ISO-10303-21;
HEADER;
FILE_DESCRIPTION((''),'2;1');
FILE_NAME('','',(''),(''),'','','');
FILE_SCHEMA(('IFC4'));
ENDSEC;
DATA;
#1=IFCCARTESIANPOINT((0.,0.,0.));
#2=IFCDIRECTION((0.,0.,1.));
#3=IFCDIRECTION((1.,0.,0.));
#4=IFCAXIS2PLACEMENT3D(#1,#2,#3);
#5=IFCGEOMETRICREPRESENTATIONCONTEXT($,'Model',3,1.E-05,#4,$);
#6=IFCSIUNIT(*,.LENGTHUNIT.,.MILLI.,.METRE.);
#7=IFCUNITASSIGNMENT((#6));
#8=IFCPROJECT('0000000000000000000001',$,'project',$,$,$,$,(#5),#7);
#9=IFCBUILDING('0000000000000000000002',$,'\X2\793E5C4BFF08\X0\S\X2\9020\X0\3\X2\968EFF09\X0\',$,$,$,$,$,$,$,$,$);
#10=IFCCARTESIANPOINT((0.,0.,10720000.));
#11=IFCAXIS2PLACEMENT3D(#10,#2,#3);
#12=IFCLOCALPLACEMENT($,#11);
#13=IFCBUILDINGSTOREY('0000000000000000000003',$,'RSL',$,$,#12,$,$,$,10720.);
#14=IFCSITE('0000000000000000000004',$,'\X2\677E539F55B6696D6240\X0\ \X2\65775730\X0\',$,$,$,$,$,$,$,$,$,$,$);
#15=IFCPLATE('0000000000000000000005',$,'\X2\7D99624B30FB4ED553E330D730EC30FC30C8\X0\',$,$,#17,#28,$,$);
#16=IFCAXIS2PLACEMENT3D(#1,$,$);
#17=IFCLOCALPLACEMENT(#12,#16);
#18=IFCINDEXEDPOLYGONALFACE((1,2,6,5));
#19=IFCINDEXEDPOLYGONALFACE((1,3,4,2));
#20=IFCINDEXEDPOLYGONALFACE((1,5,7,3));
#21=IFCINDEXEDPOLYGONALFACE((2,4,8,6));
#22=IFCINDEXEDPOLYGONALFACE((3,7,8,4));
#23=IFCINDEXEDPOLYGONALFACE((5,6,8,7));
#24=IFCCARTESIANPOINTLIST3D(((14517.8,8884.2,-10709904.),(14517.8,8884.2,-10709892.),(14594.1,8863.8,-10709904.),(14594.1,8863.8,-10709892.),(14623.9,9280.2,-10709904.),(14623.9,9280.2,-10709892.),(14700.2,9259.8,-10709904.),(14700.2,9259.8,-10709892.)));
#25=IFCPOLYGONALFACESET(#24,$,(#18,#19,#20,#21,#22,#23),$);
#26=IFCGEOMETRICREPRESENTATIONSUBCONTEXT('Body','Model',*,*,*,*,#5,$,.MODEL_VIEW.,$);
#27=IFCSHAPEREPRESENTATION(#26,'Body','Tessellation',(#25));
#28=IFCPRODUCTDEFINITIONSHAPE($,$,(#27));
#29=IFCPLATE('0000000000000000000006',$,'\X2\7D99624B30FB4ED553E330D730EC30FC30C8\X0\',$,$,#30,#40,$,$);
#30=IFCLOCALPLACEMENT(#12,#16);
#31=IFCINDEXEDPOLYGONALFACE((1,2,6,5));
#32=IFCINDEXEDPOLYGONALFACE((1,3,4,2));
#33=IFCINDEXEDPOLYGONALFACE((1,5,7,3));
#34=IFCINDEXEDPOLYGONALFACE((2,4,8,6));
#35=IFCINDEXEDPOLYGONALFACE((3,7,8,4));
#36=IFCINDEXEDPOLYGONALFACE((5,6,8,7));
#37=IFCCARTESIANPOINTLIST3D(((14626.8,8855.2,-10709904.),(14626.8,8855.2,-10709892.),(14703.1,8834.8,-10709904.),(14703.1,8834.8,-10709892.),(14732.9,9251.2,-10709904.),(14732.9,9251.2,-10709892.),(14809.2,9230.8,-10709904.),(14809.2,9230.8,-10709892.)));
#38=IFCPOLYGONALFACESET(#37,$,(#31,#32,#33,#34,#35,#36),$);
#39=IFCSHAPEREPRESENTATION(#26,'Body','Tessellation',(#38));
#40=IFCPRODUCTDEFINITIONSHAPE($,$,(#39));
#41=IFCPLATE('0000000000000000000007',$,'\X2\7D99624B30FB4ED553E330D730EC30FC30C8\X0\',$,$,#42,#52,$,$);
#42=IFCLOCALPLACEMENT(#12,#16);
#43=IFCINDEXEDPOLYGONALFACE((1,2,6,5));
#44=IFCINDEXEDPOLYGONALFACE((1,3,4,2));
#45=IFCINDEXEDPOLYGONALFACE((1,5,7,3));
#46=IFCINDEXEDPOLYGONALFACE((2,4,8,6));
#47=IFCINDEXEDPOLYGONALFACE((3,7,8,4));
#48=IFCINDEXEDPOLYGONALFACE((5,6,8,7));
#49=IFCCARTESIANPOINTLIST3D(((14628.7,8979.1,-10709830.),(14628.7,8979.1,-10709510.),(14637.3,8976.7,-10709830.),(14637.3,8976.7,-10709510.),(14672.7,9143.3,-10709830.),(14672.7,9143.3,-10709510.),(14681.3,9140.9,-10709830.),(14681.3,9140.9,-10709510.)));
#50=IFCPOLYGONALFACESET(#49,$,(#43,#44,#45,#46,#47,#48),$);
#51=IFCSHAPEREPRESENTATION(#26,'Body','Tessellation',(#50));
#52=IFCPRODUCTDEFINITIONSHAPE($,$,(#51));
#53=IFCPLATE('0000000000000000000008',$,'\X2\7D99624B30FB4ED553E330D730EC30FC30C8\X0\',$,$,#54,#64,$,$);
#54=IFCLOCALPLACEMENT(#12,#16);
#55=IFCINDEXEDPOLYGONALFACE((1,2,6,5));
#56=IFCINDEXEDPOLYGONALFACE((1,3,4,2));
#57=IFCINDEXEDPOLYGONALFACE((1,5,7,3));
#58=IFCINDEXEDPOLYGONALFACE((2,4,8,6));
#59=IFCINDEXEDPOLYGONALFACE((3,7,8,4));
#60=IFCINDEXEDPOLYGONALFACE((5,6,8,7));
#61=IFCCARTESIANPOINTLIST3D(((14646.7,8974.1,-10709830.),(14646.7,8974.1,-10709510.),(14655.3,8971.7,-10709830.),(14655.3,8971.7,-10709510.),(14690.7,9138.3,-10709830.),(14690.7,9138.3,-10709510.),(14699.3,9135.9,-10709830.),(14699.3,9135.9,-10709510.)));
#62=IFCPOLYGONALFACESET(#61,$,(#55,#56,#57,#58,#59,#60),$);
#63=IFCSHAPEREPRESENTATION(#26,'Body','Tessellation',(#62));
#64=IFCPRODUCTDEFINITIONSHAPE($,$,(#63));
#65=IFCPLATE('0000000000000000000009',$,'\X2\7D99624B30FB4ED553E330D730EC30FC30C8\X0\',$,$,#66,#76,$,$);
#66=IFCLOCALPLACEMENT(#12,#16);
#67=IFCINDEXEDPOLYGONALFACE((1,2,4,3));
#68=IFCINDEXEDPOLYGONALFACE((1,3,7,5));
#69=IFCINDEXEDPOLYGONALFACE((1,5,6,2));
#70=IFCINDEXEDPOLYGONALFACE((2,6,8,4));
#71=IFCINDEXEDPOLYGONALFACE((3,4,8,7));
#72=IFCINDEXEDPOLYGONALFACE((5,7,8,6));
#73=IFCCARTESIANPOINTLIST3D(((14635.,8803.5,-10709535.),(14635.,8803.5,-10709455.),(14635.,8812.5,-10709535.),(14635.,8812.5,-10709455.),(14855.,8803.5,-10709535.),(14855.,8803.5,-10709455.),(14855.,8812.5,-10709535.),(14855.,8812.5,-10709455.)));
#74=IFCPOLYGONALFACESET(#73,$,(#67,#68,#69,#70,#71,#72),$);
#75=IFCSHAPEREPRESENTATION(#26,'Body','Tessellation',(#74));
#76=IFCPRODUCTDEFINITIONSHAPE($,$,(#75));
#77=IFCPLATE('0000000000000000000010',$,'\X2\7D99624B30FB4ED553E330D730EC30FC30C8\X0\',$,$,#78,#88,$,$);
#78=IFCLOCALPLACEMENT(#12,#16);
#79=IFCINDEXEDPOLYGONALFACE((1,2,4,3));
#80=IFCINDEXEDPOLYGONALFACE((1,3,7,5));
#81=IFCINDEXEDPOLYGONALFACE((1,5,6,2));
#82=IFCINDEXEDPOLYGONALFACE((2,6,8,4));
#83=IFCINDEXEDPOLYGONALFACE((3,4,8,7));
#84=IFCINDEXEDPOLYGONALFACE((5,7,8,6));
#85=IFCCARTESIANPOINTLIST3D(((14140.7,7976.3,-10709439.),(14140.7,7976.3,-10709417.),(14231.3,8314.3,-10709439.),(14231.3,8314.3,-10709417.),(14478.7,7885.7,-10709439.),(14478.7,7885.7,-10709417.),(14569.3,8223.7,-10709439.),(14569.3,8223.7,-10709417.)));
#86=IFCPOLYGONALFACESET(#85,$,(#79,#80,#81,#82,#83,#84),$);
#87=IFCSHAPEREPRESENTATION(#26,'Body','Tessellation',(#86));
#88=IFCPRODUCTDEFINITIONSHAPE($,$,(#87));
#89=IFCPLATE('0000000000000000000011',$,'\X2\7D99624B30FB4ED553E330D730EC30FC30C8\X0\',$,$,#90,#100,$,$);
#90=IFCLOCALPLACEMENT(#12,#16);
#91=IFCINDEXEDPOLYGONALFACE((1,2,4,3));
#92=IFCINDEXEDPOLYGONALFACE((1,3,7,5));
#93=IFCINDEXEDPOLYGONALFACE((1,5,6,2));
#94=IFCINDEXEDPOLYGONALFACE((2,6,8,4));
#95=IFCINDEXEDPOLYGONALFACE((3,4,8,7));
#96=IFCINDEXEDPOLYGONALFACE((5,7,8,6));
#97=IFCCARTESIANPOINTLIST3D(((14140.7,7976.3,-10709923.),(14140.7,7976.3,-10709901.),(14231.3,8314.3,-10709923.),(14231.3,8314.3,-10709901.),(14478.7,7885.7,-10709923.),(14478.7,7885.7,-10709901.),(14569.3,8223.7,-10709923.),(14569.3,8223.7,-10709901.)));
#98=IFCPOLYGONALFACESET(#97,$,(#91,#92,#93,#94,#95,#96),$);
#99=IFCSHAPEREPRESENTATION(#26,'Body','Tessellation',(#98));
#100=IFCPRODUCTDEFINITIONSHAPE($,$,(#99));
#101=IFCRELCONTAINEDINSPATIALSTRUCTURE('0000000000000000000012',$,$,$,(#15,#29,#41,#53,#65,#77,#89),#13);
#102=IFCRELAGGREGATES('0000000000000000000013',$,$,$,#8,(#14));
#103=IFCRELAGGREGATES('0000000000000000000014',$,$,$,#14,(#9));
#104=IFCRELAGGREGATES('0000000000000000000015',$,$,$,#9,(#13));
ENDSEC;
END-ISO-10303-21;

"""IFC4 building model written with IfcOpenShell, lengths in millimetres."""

from ifc_helpers import new_model, si_unit, frame, origin, origin_with_axes, place, context, subcontext, project, spatial, rectangle, extrude, element, save


model = new_model("IFC4")

# Units and contexts
model_context = context("Model", 3, precision=1e-05, world=origin_with_axes())
body_context = subcontext(model_context, "Body", "Model", "MODEL_VIEW")
ifc_project = project(units=[si_unit("LENGTHUNIT", "METRE", prefix="MILLI")], contexts=[model_context])

# Site, building, storey
site = spatial("IfcSite", under=ifc_project, Name="松原営業所 敷地")
building = spatial("IfcBuilding", under=site, Name="社屋（S造3階）")
storey_placement = place(None, frame((0.0, 0.0, 10720000.0), z_axis=(0.0, 0.0, 1.0), x_axis=(1.0, 0.0, 0.0)))
storey = spatial("IfcBuildingStorey", under=building, at=storey_placement, Name="RSL", Elevation=10720.0)

# Plates
for number, where, z_axis, x_axis, name in (
    (1, (14555.9, 8874.0, -10709898.0), (0.258819, 0.965926, 0.0), (-0.965926, 0.258819, 0.0), "継手・仕口プレート"),
    (2, (14664.9, 8845.0, -10709898.0), (0.258819, 0.965926, 0.0), (-0.965926, 0.258819, 0.0), "継手・仕口プレート"),
):
    element("IfcPlate", number, at=place(storey_placement, frame(where, z_axis=z_axis, x_axis=x_axis)), inside=storey, Name=name, context=body_context, shape_type="SweptSolid", body=[
        extrude(rectangle(XDim=79.0, YDim=12.0), origin(), (0.0, 0.0, 1.0), 410.0),
    ])
for number, where, z_axis, x_axis, name in (
    (3, (14633.0, 8977.9, -10709670.0), (0.258819, 0.965926, 0.0), (-0.965926, 0.258819, 0.0), "継手・仕口プレート"),
    (4, (14651.0, 8972.9, -10709670.0), (0.258819, 0.965926, 0.0), (-0.965926, 0.258819, 0.0), "継手・仕口プレート"),
):
    element("IfcPlate", number, at=place(storey_placement, frame(where, z_axis=z_axis, x_axis=x_axis)), inside=storey, Name=name, context=body_context, shape_type="SweptSolid", body=[
        extrude(rectangle(XDim=9.0, YDim=320.0), origin(), (0.0, 0.0, 1.0), 170.0),
    ])
plate_1_placement = place(storey_placement, frame((14635.0, 8808.0, -10709495.0), z_axis=(1.0, 0.0, 0.0), x_axis=(0.0, 1.0, 0.0)))
element("IfcPlate", 5, at=plate_1_placement, inside=storey, Name="継手・仕口プレート", context=body_context, shape_type="SweptSolid", body=[
    extrude(rectangle(XDim=9.0, YDim=80.0), origin(), (0.0, 0.0, 1.0), 220.0),
])
for number, where, z_axis, x_axis, name in (
    (6, (14186.0, 8145.3, -10709428.0), (0.965926, -0.258819, 0.0), (0.258819, 0.965926, 0.0), "継手・仕口プレート"),
    (7, (14186.0, 8145.3, -10709912.0), (0.965926, -0.258819, 0.0), (0.258819, 0.965926, 0.0), "継手・仕口プレート"),
):
    element("IfcPlate", number, at=place(storey_placement, frame(where, z_axis=z_axis, x_axis=x_axis)), inside=storey, Name=name, context=body_context, shape_type="SweptSolid", body=[
        extrude(rectangle(XDim=350.0, YDim=22.0), origin(), (0.0, 0.0, 1.0), 350.0),
    ])

save(model, "model.ifc")
